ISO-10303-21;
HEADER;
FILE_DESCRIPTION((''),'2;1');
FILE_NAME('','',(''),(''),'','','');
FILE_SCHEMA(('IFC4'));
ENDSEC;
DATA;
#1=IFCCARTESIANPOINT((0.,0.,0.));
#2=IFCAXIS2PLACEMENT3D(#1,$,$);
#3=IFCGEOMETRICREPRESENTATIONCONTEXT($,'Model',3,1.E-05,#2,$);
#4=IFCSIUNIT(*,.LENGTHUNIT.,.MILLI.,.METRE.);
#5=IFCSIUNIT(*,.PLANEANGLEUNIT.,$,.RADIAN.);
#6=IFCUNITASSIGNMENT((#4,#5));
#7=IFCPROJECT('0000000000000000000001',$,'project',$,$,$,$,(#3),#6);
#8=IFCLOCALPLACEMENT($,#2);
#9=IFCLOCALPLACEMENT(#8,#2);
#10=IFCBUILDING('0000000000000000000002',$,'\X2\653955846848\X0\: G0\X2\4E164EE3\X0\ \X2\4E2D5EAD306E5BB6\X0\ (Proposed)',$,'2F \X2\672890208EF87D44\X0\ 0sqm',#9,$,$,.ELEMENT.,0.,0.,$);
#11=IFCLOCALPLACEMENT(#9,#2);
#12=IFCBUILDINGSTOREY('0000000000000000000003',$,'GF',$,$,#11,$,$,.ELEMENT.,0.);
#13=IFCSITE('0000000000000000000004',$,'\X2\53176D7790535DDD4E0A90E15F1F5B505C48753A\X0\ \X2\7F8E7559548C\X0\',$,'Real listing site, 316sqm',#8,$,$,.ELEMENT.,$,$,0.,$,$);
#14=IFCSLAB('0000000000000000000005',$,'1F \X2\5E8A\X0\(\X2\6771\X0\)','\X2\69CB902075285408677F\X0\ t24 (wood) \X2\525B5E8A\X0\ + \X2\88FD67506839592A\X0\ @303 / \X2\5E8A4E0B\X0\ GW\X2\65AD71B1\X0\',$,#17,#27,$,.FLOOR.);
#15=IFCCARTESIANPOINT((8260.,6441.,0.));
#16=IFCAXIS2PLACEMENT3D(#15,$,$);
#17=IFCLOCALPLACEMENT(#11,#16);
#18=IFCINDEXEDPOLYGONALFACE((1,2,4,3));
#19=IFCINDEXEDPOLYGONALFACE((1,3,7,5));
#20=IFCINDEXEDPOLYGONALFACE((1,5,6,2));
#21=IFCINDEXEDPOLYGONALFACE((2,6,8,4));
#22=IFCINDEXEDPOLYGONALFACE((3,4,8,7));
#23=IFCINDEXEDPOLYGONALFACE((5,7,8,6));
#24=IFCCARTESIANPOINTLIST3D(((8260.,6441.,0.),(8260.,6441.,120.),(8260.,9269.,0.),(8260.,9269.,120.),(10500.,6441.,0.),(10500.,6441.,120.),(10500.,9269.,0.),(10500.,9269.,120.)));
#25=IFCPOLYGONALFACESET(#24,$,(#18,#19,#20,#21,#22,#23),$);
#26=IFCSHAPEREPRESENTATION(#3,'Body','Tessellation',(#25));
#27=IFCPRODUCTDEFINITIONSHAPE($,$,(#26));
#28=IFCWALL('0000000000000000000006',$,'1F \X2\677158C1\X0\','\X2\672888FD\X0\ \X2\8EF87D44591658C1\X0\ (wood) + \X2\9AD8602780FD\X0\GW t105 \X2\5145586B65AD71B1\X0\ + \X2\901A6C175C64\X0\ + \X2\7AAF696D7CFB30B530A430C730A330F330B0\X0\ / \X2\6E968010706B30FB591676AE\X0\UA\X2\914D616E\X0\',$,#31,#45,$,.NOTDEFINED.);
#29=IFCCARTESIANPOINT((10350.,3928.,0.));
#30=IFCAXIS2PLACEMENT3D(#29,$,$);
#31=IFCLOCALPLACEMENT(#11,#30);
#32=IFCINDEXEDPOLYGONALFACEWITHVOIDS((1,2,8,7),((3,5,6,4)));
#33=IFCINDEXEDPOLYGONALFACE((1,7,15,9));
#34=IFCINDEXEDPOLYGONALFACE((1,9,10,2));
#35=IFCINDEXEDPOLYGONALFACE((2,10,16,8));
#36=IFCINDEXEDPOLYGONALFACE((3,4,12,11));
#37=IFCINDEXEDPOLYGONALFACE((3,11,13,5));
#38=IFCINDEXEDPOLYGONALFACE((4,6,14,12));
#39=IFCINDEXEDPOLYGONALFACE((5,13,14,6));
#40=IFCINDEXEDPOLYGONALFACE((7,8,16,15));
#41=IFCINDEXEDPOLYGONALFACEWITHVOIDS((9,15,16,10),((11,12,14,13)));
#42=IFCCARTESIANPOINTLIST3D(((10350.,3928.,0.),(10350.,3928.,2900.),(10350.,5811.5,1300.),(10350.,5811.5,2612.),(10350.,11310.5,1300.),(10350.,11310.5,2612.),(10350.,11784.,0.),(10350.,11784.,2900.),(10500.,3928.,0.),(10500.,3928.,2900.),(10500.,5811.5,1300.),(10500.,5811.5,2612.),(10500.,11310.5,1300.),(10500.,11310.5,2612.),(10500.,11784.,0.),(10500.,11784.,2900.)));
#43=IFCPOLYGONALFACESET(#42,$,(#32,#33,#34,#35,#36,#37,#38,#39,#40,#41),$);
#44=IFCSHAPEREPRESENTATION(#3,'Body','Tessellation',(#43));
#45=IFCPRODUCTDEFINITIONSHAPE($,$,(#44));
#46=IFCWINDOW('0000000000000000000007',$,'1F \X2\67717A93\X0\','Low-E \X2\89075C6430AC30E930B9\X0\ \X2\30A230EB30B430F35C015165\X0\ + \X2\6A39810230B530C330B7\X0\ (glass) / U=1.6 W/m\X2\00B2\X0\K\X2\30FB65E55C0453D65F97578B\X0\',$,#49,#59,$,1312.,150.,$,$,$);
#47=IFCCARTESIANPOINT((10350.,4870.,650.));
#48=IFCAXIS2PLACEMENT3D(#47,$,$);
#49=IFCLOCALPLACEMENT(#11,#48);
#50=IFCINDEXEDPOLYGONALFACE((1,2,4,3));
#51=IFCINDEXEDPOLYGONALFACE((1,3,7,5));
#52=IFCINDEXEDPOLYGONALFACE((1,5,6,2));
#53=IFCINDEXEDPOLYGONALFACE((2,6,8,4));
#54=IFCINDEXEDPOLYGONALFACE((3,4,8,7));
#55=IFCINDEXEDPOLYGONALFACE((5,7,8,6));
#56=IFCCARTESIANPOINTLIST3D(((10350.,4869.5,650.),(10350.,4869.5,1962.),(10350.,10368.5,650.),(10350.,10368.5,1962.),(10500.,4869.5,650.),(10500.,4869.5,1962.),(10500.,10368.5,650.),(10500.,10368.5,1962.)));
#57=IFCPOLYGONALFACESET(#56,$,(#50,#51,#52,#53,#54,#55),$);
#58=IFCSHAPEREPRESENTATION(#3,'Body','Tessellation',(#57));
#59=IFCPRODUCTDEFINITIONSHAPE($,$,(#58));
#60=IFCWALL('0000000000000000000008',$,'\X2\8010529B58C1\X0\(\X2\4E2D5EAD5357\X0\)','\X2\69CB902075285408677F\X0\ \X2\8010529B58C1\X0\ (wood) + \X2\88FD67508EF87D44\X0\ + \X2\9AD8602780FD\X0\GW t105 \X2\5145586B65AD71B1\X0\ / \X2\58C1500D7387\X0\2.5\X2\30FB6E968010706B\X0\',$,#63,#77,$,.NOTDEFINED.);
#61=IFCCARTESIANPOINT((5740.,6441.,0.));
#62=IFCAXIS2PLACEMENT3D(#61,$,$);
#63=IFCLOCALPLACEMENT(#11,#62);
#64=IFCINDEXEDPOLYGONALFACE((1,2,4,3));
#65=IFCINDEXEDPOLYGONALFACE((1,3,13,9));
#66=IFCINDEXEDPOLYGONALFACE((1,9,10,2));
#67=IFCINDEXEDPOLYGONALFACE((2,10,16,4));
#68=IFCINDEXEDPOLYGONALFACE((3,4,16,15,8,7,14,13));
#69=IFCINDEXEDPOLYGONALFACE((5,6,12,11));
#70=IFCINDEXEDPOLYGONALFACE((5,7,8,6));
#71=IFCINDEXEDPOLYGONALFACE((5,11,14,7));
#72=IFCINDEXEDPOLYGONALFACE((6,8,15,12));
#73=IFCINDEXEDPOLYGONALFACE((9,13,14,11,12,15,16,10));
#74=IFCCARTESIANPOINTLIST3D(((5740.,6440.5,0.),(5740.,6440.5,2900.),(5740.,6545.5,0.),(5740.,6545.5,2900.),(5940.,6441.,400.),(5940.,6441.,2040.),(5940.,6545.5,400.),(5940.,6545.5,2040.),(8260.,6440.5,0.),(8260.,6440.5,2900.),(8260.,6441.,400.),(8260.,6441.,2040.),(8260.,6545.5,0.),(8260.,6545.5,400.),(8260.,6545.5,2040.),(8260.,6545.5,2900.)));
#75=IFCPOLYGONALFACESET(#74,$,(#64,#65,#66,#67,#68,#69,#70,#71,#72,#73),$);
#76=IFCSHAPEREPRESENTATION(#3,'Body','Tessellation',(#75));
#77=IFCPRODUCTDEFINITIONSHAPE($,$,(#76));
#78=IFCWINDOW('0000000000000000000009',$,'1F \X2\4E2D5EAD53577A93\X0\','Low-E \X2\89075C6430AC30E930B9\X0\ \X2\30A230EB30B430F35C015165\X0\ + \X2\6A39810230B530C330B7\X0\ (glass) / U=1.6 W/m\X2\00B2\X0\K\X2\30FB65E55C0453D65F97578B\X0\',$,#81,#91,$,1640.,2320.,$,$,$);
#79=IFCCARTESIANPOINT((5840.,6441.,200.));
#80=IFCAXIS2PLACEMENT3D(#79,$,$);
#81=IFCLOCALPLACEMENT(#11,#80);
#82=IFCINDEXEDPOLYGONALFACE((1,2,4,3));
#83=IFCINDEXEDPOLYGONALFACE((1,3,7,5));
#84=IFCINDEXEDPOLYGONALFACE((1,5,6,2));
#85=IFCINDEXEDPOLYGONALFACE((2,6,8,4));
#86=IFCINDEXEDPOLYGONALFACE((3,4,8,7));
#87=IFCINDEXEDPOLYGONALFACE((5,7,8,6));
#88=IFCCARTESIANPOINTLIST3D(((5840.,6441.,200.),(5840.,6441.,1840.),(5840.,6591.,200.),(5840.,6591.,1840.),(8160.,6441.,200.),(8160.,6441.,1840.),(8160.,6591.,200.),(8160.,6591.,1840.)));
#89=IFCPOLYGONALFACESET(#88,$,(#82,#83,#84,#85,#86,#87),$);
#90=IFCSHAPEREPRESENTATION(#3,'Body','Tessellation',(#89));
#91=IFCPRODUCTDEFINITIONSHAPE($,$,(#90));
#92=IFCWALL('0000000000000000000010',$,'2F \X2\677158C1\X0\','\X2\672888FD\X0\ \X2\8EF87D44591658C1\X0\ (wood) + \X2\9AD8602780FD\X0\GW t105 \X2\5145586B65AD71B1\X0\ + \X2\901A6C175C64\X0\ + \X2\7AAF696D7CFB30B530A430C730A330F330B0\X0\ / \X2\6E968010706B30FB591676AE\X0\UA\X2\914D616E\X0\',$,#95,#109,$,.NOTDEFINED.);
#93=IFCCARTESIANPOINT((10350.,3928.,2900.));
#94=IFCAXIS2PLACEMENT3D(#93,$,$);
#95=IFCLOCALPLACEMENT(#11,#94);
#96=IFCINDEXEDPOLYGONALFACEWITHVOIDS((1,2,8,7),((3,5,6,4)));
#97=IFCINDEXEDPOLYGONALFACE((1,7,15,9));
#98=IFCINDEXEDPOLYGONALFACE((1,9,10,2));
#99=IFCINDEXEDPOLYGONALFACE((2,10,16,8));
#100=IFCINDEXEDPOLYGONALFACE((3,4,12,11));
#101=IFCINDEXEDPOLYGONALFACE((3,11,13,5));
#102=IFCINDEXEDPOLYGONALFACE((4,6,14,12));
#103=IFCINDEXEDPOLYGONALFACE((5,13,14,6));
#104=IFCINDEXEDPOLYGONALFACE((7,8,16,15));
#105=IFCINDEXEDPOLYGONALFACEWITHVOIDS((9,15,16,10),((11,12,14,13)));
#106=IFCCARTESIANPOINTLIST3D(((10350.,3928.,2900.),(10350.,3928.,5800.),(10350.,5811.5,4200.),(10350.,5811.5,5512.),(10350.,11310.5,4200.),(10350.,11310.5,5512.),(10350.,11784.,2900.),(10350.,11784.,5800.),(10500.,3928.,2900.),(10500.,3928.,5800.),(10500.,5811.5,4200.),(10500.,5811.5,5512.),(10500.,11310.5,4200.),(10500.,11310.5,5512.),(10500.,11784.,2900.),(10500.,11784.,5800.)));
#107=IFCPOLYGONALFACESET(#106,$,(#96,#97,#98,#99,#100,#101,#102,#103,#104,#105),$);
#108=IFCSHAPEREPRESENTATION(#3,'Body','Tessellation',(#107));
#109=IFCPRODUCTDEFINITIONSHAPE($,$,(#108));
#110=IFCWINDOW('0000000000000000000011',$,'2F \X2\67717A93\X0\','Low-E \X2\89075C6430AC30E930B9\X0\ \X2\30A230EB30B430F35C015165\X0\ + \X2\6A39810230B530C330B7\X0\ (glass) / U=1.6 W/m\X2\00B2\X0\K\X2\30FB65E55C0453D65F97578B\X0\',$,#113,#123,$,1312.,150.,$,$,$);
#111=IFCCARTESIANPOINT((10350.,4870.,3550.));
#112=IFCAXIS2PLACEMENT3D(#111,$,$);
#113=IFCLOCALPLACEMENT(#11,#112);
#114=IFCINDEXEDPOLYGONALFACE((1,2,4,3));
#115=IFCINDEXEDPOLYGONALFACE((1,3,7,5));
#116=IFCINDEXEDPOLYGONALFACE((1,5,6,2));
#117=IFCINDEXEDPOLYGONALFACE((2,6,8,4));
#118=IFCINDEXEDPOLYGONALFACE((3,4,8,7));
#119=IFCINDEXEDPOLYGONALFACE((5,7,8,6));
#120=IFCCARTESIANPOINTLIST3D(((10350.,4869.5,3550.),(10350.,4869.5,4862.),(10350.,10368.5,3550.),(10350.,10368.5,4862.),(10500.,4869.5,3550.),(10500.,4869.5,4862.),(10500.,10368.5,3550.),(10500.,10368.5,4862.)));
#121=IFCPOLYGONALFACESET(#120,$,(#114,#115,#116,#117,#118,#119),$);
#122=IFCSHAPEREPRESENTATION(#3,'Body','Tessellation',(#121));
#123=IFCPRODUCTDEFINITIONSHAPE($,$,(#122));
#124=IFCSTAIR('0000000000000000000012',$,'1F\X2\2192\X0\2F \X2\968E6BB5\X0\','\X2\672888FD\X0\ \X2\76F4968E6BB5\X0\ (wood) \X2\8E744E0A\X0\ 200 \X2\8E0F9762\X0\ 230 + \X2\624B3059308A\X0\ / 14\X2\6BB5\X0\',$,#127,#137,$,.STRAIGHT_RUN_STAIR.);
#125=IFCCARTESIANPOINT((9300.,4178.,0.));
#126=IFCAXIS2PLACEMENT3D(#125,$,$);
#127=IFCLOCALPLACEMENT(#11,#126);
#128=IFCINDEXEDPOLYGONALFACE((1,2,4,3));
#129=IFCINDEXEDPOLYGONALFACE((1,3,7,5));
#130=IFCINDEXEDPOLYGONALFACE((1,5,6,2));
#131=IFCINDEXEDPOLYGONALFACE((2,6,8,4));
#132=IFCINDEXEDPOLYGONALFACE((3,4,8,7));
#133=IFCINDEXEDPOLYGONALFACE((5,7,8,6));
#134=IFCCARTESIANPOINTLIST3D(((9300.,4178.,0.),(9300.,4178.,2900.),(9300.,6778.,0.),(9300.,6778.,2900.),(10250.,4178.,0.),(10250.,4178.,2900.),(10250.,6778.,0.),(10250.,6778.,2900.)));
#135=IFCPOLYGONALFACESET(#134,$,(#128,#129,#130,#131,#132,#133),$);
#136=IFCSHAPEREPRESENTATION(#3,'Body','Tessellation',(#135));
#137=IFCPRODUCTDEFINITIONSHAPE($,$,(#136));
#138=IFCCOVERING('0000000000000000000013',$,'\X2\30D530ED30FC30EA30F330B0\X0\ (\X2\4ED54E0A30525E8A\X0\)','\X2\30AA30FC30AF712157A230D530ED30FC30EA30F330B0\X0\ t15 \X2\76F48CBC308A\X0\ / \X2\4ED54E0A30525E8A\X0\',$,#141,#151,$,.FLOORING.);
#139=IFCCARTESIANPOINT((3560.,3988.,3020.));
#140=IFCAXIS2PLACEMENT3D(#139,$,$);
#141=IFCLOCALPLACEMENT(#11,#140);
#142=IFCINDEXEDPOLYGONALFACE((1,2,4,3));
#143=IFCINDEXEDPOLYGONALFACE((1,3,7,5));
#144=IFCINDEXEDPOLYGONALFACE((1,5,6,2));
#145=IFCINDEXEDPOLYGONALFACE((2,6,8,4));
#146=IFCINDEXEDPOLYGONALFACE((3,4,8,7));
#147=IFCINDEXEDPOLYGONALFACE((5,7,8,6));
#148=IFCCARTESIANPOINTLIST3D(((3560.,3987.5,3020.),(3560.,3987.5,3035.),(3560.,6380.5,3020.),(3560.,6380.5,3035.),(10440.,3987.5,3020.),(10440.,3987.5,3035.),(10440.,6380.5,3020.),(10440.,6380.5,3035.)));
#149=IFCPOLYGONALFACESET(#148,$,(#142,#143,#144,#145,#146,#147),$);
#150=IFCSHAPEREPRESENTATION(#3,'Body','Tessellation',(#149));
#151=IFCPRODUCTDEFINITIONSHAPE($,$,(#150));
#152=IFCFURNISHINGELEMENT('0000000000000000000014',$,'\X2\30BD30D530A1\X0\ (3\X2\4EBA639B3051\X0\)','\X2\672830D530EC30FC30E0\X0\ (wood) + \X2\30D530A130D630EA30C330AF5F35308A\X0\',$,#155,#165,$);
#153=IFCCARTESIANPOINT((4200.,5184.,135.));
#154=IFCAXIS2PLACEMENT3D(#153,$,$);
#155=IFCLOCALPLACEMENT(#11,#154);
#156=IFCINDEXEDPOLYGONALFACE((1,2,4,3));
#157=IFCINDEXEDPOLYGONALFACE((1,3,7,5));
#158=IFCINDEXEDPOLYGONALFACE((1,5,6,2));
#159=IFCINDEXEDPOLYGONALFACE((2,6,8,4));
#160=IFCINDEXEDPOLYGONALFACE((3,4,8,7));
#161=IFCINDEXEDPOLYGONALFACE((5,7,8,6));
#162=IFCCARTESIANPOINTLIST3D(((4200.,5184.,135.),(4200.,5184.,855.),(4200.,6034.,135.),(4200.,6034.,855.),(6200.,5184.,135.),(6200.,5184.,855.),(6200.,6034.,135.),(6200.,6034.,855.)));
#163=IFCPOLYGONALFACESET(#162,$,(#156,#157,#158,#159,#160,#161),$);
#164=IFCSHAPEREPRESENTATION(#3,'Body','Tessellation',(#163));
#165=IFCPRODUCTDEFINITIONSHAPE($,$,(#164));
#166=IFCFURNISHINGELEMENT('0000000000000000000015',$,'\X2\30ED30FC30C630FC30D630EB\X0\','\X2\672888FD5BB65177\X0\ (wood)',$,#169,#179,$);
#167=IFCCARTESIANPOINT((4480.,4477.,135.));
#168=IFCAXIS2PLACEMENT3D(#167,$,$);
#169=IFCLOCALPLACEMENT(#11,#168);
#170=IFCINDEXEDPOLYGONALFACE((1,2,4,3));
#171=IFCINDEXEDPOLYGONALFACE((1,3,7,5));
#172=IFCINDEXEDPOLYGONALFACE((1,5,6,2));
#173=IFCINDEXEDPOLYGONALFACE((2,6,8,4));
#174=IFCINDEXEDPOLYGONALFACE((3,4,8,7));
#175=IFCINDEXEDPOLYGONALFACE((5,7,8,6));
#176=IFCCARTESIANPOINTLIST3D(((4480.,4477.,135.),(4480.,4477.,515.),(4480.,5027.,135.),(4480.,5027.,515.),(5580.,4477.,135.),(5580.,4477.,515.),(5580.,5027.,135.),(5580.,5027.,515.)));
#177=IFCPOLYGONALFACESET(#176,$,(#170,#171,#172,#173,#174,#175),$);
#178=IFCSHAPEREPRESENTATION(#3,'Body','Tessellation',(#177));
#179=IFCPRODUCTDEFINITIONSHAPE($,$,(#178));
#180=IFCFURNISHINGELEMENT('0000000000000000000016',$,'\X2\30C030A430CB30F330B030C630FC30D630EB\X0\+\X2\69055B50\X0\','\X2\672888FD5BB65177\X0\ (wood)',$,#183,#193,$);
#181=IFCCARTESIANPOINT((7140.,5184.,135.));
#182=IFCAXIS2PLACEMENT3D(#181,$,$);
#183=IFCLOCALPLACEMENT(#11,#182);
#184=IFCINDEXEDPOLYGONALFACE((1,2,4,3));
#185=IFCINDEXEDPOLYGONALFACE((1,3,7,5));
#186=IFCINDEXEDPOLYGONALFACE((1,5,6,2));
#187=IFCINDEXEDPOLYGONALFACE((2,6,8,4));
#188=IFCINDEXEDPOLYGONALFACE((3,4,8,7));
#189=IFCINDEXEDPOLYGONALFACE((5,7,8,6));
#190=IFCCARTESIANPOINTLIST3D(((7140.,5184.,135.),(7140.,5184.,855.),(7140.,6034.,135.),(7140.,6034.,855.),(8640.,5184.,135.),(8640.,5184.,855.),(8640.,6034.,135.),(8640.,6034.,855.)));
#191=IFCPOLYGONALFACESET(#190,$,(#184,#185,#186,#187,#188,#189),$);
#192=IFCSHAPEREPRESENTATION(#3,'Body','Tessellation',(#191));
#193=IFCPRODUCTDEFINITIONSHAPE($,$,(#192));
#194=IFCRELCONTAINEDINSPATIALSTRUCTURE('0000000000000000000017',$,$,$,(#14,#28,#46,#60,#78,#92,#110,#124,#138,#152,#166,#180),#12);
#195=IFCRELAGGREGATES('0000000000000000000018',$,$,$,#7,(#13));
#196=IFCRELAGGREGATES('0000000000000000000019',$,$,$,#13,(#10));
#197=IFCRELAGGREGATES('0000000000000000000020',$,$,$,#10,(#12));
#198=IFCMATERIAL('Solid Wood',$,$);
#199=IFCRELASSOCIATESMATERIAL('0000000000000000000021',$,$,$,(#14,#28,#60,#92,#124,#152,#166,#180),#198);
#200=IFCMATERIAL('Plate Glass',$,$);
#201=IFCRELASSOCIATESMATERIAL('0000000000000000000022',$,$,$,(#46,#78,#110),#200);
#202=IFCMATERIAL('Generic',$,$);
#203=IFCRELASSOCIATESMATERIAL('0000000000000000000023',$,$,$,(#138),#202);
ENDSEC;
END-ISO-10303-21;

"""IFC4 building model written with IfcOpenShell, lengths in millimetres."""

from ifc_helpers import new_model, si_unit, frame, frame_2d, origin, place, context, project, spatial, rectangle, extrude, material, element, fill, save


model = new_model("IFC4")

# Units and contexts
model_context = context("Model", 3, precision=1e-05, world=origin())
ifc_project = project(units=[si_unit("LENGTHUNIT", "METRE", prefix="MILLI"), si_unit("PLANEANGLEUNIT", "RADIAN")], contexts=[model_context])

# Site, building, storey
site_placement = place(None, origin())
site = spatial("IfcSite", under=ifc_project, at=site_placement, Name="北海道川上郡弟子屈町 美留和", ObjectType="Real listing site, 316sqm", CompositionType="ELEMENT", RefElevation=0.0)
building_placement = place(site_placement, origin())
building = spatial("IfcBuilding", under=site, at=building_placement, Name="改善案: G0世代 中庭の家 (Proposed)", ObjectType="2F 木造軸組 0sqm", CompositionType="ELEMENT", ElevationOfRefHeight=0.0, ElevationOfTerrain=0.0)
storey_placement = place(building_placement, origin())
storey = spatial("IfcBuildingStorey", under=building, at=storey_placement, Name="GF", CompositionType="ELEMENT", Elevation=0.0)

# Slab
ifc_material_1 = material(Name="Solid Wood")
slab_placement = place(storey_placement, frame((8260.0, 6441.0, 0.0)))
element("IfcSlab", 1, at=slab_placement, inside=storey, material=ifc_material_1, Name="1F 床(東)", Description="構造用合板 t24 (wood) 剛床 + 製材根太 @303 / 床下 GW断熱", PredefinedType="FLOOR", context=model_context, shape_type="SweptSolid", body=[
    extrude(rectangle(XDim=2240.0, YDim=2828.0, at=frame_2d((1120.0, 1414.0))), frame((8260.0, 6441.0, 0.0)), (0.0, 0.0, 1.0), 120.0),
])

# Walls, openings, windows
wall_1_placement = place(storey_placement, frame((10350.0, 3928.0, 0.0)))
wall_1 = element("IfcWall", 2, at=wall_1_placement, inside=storey, material=ifc_material_1, Name="1F 東壁", Description="木製 軸組外壁 (wood) + 高性能GW t105 充填断熱 + 通気層 + 窯業系サイディング / 準耐火・外皮UA配慮", PredefinedType="NOTDEFINED", context=model_context, shape_type="SweptSolid", body=[
    extrude(rectangle(XDim=150.0, YDim=7856.0, at=frame_2d((75.0, 3928.0))), frame((10350.0, 3928.0, 0.0)), (0.0, 0.0, 1.0), 2900.0),
])
opening_1_placement = place(storey_placement, frame((10350.0, 4870.0, 650.0)))
opening_1 = element("IfcOpeningElement", 3, at=opening_1_placement, cuts=wall_1, PredefinedType="NOTDEFINED", context=model_context, shape_type="SweptSolid", body=[
    extrude(rectangle(XDim=150.0, YDim=5499.0, at=frame_2d((75.0, 2749.0))), frame((10350.0, 4870.0, 650.0)), (0.0, 0.0, 1.0), 1312.0),
])
ifc_material_2 = material(Name="Plate Glass")
window_1_placement = place(storey_placement, frame((10350.0, 4870.0, 650.0)))
window_1 = element("IfcWindow", 4, at=window_1_placement, inside=storey, material=ifc_material_2, Name="1F 東窓", Description="Low-E 複層ガラス アルゴン封入 + 樹脂サッシ (glass) / U=1.6 W/m²K・日射取得型", OverallHeight=1312.0, OverallWidth=150.0, context=model_context, shape_type="SweptSolid", body=[
    extrude(rectangle(XDim=150.0, YDim=5499.0, at=frame_2d((75.0, 2749.0))), frame((10350.0, 4870.0, 650.0)), (0.0, 0.0, 1.0), 1312.0),
])
fill(opening_1, window_1)
wall_2_placement = place(storey_placement, frame((5740.0, 6441.0, 0.0)))
wall_2 = element("IfcWall", 5, at=wall_2_placement, inside=storey, material=ifc_material_1, Name="耐力壁(中庭南)", Description="構造用合板 耐力壁 (wood) + 製材軸組 + 高性能GW t105 充填断熱 / 壁倍率2.5・準耐火", PredefinedType="NOTDEFINED", context=model_context, shape_type="SweptSolid", body=[
    extrude(rectangle(XDim=2520.0, YDim=105.0, at=frame_2d((1260.0, 52.0))), frame((5740.0, 6441.0, 0.0)), (0.0, 0.0, 1.0), 2900.0),
])
opening_2_placement = place(storey_placement, frame((5840.0, 6441.0, 200.0)))
opening_2 = element("IfcOpeningElement", 6, at=opening_2_placement, cuts=wall_2, PredefinedType="NOTDEFINED", context=model_context, shape_type="SweptSolid", body=[
    extrude(rectangle(XDim=2320.0, YDim=150.0, at=frame_2d((1160.0, 75.0))), frame((5840.0, 6441.0, 200.0)), (0.0, 0.0, 1.0), 1640.0),
])
window_2_placement = place(storey_placement, frame((5840.0, 6441.0, 200.0)))
window_2 = element("IfcWindow", 7, at=window_2_placement, inside=storey, material=ifc_material_2, Name="1F 中庭南窓", Description="Low-E 複層ガラス アルゴン封入 + 樹脂サッシ (glass) / U=1.6 W/m²K・日射取得型", OverallHeight=1640.0, OverallWidth=2320.0, context=model_context, shape_type="SweptSolid", body=[
    extrude(rectangle(XDim=2320.0, YDim=150.0, at=frame_2d((1160.0, 75.0))), frame((5840.0, 6441.0, 200.0)), (0.0, 0.0, 1.0), 1640.0),
])
fill(opening_2, window_2)

# Wall, opening, window
wall_3_placement = place(storey_placement, frame((10350.0, 3928.0, 2900.0)))
wall_3 = element("IfcWall", 8, at=wall_3_placement, inside=storey, material=ifc_material_1, Name="2F 東壁", Description="木製 軸組外壁 (wood) + 高性能GW t105 充填断熱 + 通気層 + 窯業系サイディング / 準耐火・外皮UA配慮", PredefinedType="NOTDEFINED", context=model_context, shape_type="SweptSolid", body=[
    extrude(rectangle(XDim=150.0, YDim=7856.0, at=frame_2d((75.0, 3928.0))), frame((10350.0, 3928.0, 2900.0)), (0.0, 0.0, 1.0), 2900.0),
])
opening_3_placement = place(storey_placement, frame((10350.0, 4870.0, 3550.0)))
opening_3 = element("IfcOpeningElement", 9, at=opening_3_placement, cuts=wall_3, PredefinedType="NOTDEFINED", context=model_context, shape_type="SweptSolid", body=[
    extrude(rectangle(XDim=150.0, YDim=5499.0, at=frame_2d((75.0, 2749.0))), frame((10350.0, 4870.0, 3550.0)), (0.0, 0.0, 1.0), 1312.0),
])
window_3_placement = place(storey_placement, frame((10350.0, 4870.0, 3550.0)))
window_3 = element("IfcWindow", 10, at=window_3_placement, inside=storey, material=ifc_material_2, Name="2F 東窓", Description="Low-E 複層ガラス アルゴン封入 + 樹脂サッシ (glass) / U=1.6 W/m²K・日射取得型", OverallHeight=1312.0, OverallWidth=150.0, context=model_context, shape_type="SweptSolid", body=[
    extrude(rectangle(XDim=150.0, YDim=5499.0, at=frame_2d((75.0, 2749.0))), frame((10350.0, 4870.0, 3550.0)), (0.0, 0.0, 1.0), 1312.0),
])
fill(opening_3, window_3)

# Stair
stair_placement = place(storey_placement, frame((9300.0, 4178.0, 0.0)))
element("IfcStair", 11, at=stair_placement, inside=storey, material=ifc_material_1, Name="1F→2F 階段", Description="木製 直階段 (wood) 蹴上 200 踏面 230 + 手すり / 14段", PredefinedType="STRAIGHT_RUN_STAIR", context=model_context, shape_type="SweptSolid", body=[
    extrude(rectangle(XDim=950.0, YDim=2600.0, at=frame_2d((475.0, 1300.0))), frame((9300.0, 4178.0, 0.0)), (0.0, 0.0, 1.0), 2900.0),
])

# Covering
ifc_material_3 = material(Name="Generic")
covering_placement = place(storey_placement, frame((3560.0, 3988.0, 3020.0)))
element("IfcCovering", 12, at=covering_placement, inside=storey, material=ifc_material_3, Name="フローリング (仕上げ床)", Description="オーク無垢フローリング t15 直貼り / 仕上げ床", PredefinedType="FLOORING", context=model_context, shape_type="SweptSolid", body=[
    extrude(rectangle(XDim=6880.0, YDim=2393.0, at=frame_2d((3440.0, 1196.0))), frame((3560.0, 3988.0, 3020.0)), (0.0, 0.0, 1.0), 15.0),
])

# Furnishing elements
furnishing_1_placement = place(storey_placement, frame((4200.0, 5184.0, 135.0)))
element("IfcFurnishingElement", 13, at=furnishing_1_placement, inside=storey, material=ifc_material_1, Name="ソファ (3人掛け)", Description="木フレーム (wood) + ファブリック張り", context=model_context, shape_type="SweptSolid", body=[
    extrude(rectangle(XDim=2000.0, YDim=850.0, at=frame_2d((1000.0, 425.0))), frame((4200.0, 5184.0, 135.0)), (0.0, 0.0, 1.0), 720.0),
])
furnishing_2_placement = place(storey_placement, frame((4480.0, 4477.0, 135.0)))
element("IfcFurnishingElement", 14, at=furnishing_2_placement, inside=storey, material=ifc_material_1, Name="ローテーブル", Description="木製家具 (wood)", context=model_context, shape_type="SweptSolid", body=[
    extrude(rectangle(XDim=1100.0, YDim=550.0, at=frame_2d((550.0, 275.0))), frame((4480.0, 4477.0, 135.0)), (0.0, 0.0, 1.0), 380.0),
])
furnishing_3_placement = place(storey_placement, frame((7140.0, 5184.0, 135.0)))
element("IfcFurnishingElement", 15, at=furnishing_3_placement, inside=storey, material=ifc_material_1, Name="ダイニングテーブル+椅子", Description="木製家具 (wood)", context=model_context, shape_type="SweptSolid", body=[
    extrude(rectangle(XDim=1500.0, YDim=850.0, at=frame_2d((750.0, 425.0))), frame((7140.0, 5184.0, 135.0)), (0.0, 0.0, 1.0), 720.0),
])

save(model, "model.ifc")
